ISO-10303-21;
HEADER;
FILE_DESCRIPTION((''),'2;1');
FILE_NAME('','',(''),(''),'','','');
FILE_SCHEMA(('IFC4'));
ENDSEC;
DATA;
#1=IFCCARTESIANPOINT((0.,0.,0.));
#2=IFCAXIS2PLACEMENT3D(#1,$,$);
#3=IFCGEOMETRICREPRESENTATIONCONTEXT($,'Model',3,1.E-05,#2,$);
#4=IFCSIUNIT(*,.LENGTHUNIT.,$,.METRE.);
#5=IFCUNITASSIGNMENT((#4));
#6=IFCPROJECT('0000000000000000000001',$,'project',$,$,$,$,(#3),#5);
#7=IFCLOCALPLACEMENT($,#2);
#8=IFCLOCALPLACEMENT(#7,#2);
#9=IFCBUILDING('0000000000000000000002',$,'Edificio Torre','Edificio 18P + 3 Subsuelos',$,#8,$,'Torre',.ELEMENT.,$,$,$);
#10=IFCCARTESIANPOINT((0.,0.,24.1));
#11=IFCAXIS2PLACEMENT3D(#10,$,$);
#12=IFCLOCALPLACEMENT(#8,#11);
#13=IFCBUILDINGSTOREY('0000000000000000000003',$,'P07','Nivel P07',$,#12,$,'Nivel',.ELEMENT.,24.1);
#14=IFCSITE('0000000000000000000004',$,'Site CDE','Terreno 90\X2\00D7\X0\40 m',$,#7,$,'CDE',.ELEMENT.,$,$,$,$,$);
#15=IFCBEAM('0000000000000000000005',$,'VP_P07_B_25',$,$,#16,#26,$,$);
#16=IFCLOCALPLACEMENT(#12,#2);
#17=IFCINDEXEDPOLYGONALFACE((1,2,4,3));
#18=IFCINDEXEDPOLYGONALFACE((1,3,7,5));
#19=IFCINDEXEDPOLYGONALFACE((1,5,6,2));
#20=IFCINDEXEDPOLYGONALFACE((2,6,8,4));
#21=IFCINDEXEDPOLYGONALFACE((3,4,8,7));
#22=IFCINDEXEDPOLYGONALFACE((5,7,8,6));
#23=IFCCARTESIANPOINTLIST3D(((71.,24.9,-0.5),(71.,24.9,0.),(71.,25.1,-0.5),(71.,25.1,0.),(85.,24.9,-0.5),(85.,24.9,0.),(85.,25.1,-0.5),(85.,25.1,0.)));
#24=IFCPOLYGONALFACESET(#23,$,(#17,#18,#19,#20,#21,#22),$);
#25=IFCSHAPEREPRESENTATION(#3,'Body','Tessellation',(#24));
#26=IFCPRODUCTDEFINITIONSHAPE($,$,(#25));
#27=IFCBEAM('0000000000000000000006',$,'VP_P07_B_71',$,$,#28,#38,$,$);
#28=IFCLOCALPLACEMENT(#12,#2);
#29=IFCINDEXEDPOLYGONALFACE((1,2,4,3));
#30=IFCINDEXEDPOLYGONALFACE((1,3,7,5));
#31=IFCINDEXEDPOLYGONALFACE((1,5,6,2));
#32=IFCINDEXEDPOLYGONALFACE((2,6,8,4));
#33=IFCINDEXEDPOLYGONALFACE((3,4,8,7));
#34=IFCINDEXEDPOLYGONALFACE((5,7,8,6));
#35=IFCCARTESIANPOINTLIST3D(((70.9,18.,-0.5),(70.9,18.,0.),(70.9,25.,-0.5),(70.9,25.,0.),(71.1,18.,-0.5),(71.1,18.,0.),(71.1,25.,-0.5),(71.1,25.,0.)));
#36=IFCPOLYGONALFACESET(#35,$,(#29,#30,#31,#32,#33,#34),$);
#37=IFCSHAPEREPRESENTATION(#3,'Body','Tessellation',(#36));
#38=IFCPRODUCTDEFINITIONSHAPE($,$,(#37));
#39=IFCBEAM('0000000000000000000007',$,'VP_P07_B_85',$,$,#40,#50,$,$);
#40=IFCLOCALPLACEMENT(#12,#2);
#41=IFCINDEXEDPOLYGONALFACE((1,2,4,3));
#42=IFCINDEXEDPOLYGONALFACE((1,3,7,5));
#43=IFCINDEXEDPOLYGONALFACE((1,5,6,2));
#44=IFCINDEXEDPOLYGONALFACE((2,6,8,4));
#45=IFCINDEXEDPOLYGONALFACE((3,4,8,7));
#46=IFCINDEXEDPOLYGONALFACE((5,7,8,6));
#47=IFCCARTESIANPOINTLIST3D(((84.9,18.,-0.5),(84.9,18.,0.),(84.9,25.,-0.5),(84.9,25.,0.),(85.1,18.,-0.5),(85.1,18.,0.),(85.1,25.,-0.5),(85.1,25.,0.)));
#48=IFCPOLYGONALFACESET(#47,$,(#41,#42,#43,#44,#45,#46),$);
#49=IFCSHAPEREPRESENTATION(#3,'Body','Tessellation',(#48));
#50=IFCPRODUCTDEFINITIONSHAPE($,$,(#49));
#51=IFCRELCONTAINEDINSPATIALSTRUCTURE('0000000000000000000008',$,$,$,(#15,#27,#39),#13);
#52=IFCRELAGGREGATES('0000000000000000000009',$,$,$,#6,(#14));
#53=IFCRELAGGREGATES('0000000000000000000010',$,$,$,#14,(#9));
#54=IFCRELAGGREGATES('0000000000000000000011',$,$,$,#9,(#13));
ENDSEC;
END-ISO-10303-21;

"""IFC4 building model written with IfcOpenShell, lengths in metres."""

from ifc_helpers import new_model, si_unit, frame, origin, origin_2d, place, context, project, spatial, rectangle, extrude, element, save


model = new_model("IFC4")

# Units and contexts
model_context = context("Model", 3, precision=1e-05, world=origin())
ifc_project = project(units=[si_unit("LENGTHUNIT", "METRE")], contexts=[model_context])

# Site, building, storey
site_placement = place(None, origin())
site = spatial("IfcSite", under=ifc_project, at=site_placement, Name="Site CDE", Description="Terreno 90×40 m", LongName="CDE", CompositionType="ELEMENT")
building_placement = place(site_placement, origin())
building = spatial("IfcBuilding", under=site, at=building_placement, Name="Edificio Torre", Description="Edificio 18P + 3 Subsuelos", LongName="Torre", CompositionType="ELEMENT")
storey_placement = place(building_placement, frame((0.0, 0.0, 24.1)))
storey = spatial("IfcBuildingStorey", under=building, at=storey_placement, Name="P07", Description="Nivel P07", LongName="Nivel", CompositionType="ELEMENT", Elevation=24.1)

# Beams
for number, where, name in (
    (1, (78.0, 25.0, -0.5), "VP_P07_B_25"),
):
    element("IfcBeam", number, at=place(storey_placement, frame(where)), inside=storey, Name=name, context=model_context, shape_type="SweptSolid", body=[
        extrude(rectangle(XDim=14.0, YDim=0.2, at=origin_2d()), origin(), (0.0, 0.0, 1.0), 0.5),
    ])
for number, where, name in (
    (2, (71.0, 21.5, -0.5), "VP_P07_B_71"),
    (3, (85.0, 21.5, -0.5), "VP_P07_B_85"),
):
    element("IfcBeam", number, at=place(storey_placement, frame(where)), inside=storey, Name=name, context=model_context, shape_type="SweptSolid", body=[
        extrude(rectangle(XDim=0.2, YDim=7.0, at=origin_2d()), origin(), (0.0, 0.0, 1.0), 0.5),
    ])

save(model, "model.ifc")
